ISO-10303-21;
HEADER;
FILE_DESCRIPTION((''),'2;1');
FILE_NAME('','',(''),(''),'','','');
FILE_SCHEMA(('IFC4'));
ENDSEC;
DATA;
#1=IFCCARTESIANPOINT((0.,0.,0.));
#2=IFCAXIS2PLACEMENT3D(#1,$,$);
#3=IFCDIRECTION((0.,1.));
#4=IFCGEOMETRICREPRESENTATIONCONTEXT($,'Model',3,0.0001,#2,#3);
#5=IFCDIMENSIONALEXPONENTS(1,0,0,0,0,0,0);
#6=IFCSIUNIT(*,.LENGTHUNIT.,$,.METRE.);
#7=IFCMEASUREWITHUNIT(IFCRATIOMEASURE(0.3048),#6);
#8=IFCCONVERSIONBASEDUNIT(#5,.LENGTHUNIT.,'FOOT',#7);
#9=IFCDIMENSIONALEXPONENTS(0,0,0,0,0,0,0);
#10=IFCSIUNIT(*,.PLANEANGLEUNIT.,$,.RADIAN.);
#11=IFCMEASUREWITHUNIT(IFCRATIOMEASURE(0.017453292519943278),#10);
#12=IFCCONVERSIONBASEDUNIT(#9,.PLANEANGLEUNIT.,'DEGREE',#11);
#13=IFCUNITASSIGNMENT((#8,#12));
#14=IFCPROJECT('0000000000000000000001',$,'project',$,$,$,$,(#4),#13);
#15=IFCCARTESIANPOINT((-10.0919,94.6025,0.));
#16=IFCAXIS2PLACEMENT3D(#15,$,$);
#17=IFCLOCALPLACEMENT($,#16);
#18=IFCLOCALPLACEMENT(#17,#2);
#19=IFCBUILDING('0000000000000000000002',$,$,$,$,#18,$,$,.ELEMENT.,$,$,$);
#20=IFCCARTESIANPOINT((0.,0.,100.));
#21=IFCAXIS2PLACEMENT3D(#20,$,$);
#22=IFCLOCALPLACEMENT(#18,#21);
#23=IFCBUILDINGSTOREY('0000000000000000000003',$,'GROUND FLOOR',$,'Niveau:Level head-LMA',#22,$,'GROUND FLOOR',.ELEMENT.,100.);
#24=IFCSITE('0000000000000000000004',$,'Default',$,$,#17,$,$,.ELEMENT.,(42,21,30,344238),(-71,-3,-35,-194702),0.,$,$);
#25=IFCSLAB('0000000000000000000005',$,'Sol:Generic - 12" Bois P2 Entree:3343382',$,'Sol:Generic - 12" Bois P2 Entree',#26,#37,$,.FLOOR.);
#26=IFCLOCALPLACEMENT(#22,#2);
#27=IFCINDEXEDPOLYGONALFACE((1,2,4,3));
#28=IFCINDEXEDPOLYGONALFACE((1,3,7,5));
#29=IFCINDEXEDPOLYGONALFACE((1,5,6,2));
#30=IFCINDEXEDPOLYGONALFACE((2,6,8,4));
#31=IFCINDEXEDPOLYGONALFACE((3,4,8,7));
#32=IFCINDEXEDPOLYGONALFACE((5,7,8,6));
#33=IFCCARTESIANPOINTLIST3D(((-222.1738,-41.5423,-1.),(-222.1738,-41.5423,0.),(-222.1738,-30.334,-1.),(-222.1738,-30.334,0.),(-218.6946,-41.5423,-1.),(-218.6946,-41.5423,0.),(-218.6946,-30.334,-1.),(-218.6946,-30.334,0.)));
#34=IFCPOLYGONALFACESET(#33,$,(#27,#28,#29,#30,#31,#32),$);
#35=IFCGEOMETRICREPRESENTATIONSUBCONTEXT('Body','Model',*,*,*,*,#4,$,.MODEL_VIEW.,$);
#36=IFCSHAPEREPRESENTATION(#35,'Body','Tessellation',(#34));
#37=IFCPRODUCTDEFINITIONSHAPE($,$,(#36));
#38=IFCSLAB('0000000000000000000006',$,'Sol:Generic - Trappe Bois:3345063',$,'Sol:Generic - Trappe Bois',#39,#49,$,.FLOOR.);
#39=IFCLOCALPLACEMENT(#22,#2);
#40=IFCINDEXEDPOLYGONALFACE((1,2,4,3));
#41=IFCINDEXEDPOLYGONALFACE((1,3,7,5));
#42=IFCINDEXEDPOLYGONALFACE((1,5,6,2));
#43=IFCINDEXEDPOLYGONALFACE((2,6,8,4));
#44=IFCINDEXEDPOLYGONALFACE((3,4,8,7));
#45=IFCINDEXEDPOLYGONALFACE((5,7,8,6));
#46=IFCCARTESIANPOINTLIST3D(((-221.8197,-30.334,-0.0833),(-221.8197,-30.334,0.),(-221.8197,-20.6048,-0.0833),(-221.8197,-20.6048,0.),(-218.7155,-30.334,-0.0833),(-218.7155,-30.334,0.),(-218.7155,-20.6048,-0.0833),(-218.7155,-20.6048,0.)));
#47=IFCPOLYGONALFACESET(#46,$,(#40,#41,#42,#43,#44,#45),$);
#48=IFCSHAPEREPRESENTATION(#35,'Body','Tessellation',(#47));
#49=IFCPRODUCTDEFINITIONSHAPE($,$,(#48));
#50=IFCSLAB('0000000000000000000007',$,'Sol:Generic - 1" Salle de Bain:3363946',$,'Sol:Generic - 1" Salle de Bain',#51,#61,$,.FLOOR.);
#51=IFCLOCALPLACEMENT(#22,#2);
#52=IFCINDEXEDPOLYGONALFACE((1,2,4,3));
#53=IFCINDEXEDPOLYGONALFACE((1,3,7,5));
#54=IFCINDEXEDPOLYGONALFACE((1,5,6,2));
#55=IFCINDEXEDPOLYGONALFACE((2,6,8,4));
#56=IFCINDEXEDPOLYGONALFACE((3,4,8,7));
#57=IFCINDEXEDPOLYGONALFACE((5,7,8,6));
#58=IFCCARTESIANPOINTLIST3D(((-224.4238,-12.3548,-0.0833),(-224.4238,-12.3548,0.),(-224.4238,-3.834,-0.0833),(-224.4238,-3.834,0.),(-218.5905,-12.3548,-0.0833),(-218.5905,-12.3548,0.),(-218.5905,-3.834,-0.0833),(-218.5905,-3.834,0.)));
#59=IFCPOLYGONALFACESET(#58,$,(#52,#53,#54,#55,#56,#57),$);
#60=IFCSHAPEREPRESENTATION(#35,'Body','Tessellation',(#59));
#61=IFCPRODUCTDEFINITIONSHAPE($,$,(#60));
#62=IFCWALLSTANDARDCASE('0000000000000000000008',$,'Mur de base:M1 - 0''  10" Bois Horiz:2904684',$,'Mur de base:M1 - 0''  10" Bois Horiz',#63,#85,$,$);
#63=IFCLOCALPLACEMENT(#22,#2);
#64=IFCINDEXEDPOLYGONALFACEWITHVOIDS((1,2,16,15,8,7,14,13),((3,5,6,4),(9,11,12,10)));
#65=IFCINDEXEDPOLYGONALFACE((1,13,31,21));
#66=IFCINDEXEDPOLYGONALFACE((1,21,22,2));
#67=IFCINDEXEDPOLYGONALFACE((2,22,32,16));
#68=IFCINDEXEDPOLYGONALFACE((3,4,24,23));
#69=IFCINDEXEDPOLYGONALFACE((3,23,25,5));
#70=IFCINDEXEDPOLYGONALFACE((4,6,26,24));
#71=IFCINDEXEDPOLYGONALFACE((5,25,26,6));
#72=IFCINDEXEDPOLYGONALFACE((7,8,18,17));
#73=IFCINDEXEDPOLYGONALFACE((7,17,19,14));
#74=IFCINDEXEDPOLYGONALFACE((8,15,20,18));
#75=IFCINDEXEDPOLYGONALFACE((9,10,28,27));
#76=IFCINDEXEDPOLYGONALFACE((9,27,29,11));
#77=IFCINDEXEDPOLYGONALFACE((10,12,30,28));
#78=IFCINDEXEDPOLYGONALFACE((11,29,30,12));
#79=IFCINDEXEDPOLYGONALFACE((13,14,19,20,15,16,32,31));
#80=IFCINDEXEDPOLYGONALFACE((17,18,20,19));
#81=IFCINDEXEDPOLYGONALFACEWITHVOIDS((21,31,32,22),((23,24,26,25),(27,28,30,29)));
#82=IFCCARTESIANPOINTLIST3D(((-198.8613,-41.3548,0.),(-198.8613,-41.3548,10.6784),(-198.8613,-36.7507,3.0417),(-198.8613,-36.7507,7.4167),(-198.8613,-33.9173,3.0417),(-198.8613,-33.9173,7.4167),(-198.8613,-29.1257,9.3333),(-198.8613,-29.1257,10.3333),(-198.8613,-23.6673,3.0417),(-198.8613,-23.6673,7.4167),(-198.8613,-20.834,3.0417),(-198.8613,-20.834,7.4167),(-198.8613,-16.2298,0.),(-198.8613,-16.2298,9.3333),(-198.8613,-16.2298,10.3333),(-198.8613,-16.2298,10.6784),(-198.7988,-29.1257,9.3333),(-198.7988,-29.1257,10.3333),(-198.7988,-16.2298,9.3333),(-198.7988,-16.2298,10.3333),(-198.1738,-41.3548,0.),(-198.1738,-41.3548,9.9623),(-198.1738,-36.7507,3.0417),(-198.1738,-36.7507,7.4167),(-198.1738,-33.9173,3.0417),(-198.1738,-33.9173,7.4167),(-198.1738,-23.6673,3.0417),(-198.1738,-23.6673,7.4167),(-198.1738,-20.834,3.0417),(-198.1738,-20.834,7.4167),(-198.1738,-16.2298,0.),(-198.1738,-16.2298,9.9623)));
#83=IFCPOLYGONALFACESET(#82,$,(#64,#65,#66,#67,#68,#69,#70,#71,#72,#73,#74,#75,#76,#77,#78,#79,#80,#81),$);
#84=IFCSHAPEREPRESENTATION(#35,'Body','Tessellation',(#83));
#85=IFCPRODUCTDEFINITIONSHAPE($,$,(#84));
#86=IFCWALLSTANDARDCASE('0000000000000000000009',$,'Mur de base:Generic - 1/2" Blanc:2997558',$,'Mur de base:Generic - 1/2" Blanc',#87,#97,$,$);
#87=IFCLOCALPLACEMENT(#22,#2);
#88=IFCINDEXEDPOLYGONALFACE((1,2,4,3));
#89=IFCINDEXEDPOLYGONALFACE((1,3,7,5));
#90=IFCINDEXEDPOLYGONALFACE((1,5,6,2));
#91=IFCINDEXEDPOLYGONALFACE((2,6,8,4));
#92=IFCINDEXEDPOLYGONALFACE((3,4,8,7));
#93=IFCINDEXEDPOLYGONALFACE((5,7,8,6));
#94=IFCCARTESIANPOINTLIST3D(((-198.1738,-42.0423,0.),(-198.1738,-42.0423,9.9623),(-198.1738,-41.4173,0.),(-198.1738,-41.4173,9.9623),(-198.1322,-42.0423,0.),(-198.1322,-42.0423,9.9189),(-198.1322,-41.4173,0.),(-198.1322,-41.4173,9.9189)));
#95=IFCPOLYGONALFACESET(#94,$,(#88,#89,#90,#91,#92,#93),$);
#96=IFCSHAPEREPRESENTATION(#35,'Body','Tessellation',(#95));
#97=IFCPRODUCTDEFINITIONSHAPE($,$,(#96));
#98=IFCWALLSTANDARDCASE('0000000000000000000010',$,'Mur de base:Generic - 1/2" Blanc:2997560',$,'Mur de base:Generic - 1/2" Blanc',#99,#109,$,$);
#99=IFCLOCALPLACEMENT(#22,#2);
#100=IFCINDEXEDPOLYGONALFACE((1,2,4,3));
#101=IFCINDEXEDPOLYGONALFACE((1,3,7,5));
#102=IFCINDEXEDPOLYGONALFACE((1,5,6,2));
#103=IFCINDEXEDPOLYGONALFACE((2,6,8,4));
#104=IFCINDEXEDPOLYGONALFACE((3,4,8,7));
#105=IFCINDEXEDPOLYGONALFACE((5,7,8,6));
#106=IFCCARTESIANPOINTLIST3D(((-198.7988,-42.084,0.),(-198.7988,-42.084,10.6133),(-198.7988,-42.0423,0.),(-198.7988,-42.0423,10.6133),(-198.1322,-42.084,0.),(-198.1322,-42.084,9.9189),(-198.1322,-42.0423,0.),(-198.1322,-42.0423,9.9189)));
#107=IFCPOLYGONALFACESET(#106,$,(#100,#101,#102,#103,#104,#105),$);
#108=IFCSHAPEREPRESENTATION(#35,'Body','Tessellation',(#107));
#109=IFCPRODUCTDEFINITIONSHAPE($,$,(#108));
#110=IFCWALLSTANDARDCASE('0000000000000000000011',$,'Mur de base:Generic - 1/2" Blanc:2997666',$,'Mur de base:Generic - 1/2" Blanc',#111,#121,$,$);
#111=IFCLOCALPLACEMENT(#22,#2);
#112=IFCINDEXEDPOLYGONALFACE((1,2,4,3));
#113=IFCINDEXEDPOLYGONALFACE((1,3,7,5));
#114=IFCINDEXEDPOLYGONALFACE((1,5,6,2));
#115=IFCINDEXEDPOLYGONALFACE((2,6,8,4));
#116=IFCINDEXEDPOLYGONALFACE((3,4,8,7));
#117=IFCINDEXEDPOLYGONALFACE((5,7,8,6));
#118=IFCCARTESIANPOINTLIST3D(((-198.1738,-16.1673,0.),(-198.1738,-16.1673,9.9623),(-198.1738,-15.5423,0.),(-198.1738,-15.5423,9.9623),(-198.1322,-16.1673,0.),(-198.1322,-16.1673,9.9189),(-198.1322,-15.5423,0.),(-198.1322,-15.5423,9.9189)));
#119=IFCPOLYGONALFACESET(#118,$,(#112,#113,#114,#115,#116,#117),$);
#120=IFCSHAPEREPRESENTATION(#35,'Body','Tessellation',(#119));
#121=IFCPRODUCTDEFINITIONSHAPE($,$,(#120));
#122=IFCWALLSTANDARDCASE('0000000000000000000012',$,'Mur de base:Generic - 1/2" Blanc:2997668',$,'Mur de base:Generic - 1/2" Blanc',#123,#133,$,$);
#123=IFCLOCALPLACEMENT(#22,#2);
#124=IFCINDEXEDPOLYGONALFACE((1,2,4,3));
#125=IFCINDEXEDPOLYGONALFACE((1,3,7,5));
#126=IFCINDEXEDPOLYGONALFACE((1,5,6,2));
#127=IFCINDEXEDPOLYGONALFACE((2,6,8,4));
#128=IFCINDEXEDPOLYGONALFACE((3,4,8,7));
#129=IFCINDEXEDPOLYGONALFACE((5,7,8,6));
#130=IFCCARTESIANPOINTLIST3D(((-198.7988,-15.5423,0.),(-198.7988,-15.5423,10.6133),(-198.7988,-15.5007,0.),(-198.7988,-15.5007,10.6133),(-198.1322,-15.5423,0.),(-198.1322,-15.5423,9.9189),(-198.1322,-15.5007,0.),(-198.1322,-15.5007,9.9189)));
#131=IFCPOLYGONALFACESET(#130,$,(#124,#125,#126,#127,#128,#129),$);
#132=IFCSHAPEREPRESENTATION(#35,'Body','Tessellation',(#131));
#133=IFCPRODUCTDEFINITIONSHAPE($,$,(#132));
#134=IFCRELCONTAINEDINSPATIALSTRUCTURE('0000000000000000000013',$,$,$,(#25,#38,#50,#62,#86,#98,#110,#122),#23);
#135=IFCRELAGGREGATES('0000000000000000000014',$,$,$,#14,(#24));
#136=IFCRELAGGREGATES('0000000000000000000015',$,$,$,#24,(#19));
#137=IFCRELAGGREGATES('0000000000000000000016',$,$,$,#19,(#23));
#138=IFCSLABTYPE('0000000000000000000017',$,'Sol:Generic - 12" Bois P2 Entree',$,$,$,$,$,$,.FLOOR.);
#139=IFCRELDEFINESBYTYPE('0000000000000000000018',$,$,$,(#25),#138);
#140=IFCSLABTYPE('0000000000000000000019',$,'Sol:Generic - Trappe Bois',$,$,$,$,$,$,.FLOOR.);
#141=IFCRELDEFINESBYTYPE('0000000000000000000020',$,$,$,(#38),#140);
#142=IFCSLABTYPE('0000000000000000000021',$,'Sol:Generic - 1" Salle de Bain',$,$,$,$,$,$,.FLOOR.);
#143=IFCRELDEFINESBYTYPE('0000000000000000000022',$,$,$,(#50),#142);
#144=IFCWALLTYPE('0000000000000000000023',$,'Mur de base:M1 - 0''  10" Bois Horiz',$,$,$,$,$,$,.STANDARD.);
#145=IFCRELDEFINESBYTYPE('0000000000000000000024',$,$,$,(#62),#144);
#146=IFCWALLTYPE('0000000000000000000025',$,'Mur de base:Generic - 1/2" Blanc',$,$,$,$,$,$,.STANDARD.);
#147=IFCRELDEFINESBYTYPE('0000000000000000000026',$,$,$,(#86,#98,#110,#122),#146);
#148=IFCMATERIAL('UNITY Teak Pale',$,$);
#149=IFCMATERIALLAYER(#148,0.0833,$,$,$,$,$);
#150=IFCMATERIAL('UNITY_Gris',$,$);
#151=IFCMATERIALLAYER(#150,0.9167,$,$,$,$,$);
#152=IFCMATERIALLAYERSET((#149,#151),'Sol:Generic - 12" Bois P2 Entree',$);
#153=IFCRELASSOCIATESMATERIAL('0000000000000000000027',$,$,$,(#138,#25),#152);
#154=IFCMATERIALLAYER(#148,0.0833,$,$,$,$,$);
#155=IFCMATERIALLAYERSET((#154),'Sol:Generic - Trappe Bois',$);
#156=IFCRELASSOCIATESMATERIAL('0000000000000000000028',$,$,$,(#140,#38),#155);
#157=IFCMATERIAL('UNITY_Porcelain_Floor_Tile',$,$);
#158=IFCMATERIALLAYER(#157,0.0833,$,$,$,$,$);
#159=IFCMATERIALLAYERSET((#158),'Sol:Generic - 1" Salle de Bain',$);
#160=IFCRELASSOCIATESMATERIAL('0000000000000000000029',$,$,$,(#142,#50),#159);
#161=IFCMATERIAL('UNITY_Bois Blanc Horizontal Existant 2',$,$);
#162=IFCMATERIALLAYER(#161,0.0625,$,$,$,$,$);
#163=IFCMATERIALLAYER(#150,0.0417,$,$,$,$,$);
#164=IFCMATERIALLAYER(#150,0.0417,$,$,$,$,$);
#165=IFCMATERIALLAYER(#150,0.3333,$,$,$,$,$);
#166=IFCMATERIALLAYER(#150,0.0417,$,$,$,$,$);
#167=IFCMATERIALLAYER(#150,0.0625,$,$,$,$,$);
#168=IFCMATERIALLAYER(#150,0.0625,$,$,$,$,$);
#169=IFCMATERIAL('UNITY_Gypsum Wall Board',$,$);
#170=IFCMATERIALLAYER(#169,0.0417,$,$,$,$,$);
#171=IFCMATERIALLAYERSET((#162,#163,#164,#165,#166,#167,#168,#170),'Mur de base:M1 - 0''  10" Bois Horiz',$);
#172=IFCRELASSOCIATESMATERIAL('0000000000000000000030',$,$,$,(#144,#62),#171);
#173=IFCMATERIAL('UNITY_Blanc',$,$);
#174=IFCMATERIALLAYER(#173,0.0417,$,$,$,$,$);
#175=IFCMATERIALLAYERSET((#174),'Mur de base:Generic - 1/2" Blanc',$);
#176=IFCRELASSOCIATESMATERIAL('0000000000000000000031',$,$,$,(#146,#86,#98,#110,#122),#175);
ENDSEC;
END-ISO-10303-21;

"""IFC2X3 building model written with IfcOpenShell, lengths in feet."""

from ifc_helpers import new_model, entity, si_unit, converted_unit, direction, frame, frame_2d, origin, place, context, subcontext, project, spatial, polyline, rectangle, extrude, clip, bounded_halfspace, material, layer, layer_set, layer_usage, type_object, element, save


model = new_model("IFC2X3")

# Units and contexts
model_context = context("Model", 3, precision=0.0001, world=origin(), true_north=direction((0.0, 1.0)))
body_context = subcontext(model_context, "Body", "Model", "MODEL_VIEW")
ifc_project = project(units=[converted_unit("LENGTHUNIT", "FOOT", entity("IfcRatioMeasure", 0.3048), si_unit("LENGTHUNIT", "METRE"), dimensions=[1, 0, 0, 0, 0, 0, 0]), converted_unit("PLANEANGLEUNIT", "DEGREE", entity("IfcRatioMeasure", 0.017453292519943278), si_unit("PLANEANGLEUNIT", "RADIAN"), dimensions=[0, 0, 0, 0, 0, 0, 0])], contexts=[model_context])

# Site, building, storey
site_placement = place(None, frame((-10.0919, 94.6025, 0.0)))
site = spatial("IfcSite", under=ifc_project, at=site_placement, Name="Default", CompositionType="ELEMENT", RefLatitude=(42, 21, 30, 344238), RefLongitude=(-71, -3, -35, -194702), RefElevation=0.0)
building_placement = place(site_placement, origin())
building = spatial("IfcBuilding", under=site, at=building_placement, CompositionType="ELEMENT")
storey_placement = place(building_placement, frame((0.0, 0.0, 100.0)))
storey = spatial("IfcBuildingStorey", under=building, at=storey_placement, Name="GROUND FLOOR", ObjectType="Niveau:Level head-LMA", LongName="GROUND FLOOR", CompositionType="ELEMENT", Elevation=100.0)

# Slabs
ifc_material_1 = material(Name="UNITY_Gris")
ifc_material_2 = material(Name="UNITY Teak Pale")
ifc_layer_1 = layer(ifc_material_2, 0.0833)
ifc_layer_2 = layer(ifc_material_1, 0.9167)
ifc_layer_set_1 = layer_set([ifc_layer_1, ifc_layer_2], Name="Sol:Generic - 12\" Bois P2 Entree")
ifc_layer_usage_1 = layer_usage(ifc_layer_set_1, "AXIS3", "POSITIVE", 0.0)
slab_type_1 = type_object("IfcSlabType", Name="Sol:Generic - 12\" Bois P2 Entree", PredefinedType="FLOOR", material=ifc_layer_set_1)
slab_1_placement = place(storey_placement, origin())
element("IfcSlab", 1, at=slab_1_placement, inside=storey, type_object=slab_type_1, material=ifc_layer_usage_1, Name="Sol:Generic - 12\" Bois P2 Entree:3343382", ObjectType="Sol:Generic - 12\" Bois P2 Entree", PredefinedType="FLOOR", context=body_context, shape_type="SweptSolid", body=[
    extrude(rectangle(XDim=11.2083, YDim=3.4792, at=frame_2d((0.0, 0.0), x_axis=(1.0, 0.0))), frame((-220.4342, -35.9382, 0.0), z_axis=(0.0, 0.0, -1.0), x_axis=(0.0, 1.0, 0.0)), (0.0, 0.0, 1.0), 1.0),
])
ifc_layer_3 = layer(ifc_material_2, 0.0833)
ifc_layer_set_2 = layer_set([ifc_layer_3], Name="Sol:Generic - Trappe Bois")
ifc_layer_usage_2 = layer_usage(ifc_layer_set_2, "AXIS3", "POSITIVE", 0.0)
slab_type_2 = type_object("IfcSlabType", Name="Sol:Generic - Trappe Bois", PredefinedType="FLOOR", material=ifc_layer_set_2)
slab_2_placement = place(storey_placement, origin())
element("IfcSlab", 2, at=slab_2_placement, inside=storey, type_object=slab_type_2, material=ifc_layer_usage_2, Name="Sol:Generic - Trappe Bois:3345063", ObjectType="Sol:Generic - Trappe Bois", PredefinedType="FLOOR", context=body_context, shape_type="SweptSolid", body=[
    extrude(rectangle(XDim=9.7292, YDim=3.1042, at=frame_2d((0.0, 0.0), x_axis=(1.0, 0.0))), frame((-220.2676, -25.4694, 0.0), z_axis=(0.0, 0.0, -1.0), x_axis=(0.0, 1.0, 0.0)), (0.0, 0.0, 1.0), 0.0833),
])
ifc_material_3 = material(Name="UNITY_Porcelain_Floor_Tile")
ifc_layer_4 = layer(ifc_material_3, 0.0833)
ifc_layer_set_3 = layer_set([ifc_layer_4], Name="Sol:Generic - 1\" Salle de Bain")
ifc_layer_usage_3 = layer_usage(ifc_layer_set_3, "AXIS3", "POSITIVE", 0.0)
slab_type_3 = type_object("IfcSlabType", Name="Sol:Generic - 1\" Salle de Bain", PredefinedType="FLOOR", material=ifc_layer_set_3)
slab_3_placement = place(storey_placement, origin())
element("IfcSlab", 3, at=slab_3_placement, inside=storey, type_object=slab_type_3, material=ifc_layer_usage_3, Name="Sol:Generic - 1\" Salle de Bain:3363946", ObjectType="Sol:Generic - 1\" Salle de Bain", PredefinedType="FLOOR", context=body_context, shape_type="SweptSolid", body=[
    extrude(rectangle(XDim=8.5208, YDim=5.8333, at=frame_2d((0.0, 0.0), x_axis=(1.0, 0.0))), frame((-221.5072, -8.0944, 0.0), z_axis=(0.0, 0.0, -1.0), x_axis=(0.0, 1.0, 0.0)), (0.0, 0.0, 1.0), 0.0833),
])

# Wall, openings
ifc_material_4 = material(Name="UNITY_Bois Blanc Horizontal Existant 2")
ifc_layer_5 = layer(ifc_material_4, 0.0625)
ifc_layer_6 = layer(ifc_material_1, 0.0417)
ifc_layer_7 = layer(ifc_material_1, 0.0417)
ifc_layer_8 = layer(ifc_material_1, 0.3333)
ifc_layer_9 = layer(ifc_material_1, 0.0417)
ifc_layer_10 = layer(ifc_material_1, 0.0625)
ifc_layer_11 = layer(ifc_material_1, 0.0625)
ifc_material_5 = material(Name="UNITY_Gypsum Wall Board")
ifc_layer_12 = layer(ifc_material_5, 0.0417)
ifc_layer_set_4 = layer_set([ifc_layer_5, ifc_layer_6, ifc_layer_7, ifc_layer_8, ifc_layer_9, ifc_layer_10, ifc_layer_11, ifc_layer_12], Name="Mur de base:M1 - 0'  10\" Bois Horiz")
ifc_layer_usage_4 = layer_usage(ifc_layer_set_4, "AXIS2", "NEGATIVE", 0.3438)
wall_type_1 = type_object("IfcWallType", Name="Mur de base:M1 - 0'  10\" Bois Horiz", PredefinedType="STANDARD", material=ifc_layer_set_4)
wall_1_placement = place(storey_placement, frame((-198.5176, -16.2298, 0.0), z_axis=(0.0, 0.0, 1.0), x_axis=(0.0, -1.0, 0.0)))
wall_1 = element("IfcWallStandardCase", 4, at=wall_1_placement, inside=storey, type_object=wall_type_1, material=ifc_layer_usage_4, Name="Mur de base:M1 - 0'  10\" Bois Horiz:2904684", ObjectType="Mur de base:M1 - 0'  10\" Bois Horiz", context=body_context, shape_type="Clipping", body=[
    clip(extrude(rectangle(XDim=25.125, YDim=0.6875, at=frame_2d((12.5625, 0.0), x_axis=(-1.0, 0.0))), origin(), (0.0, 0.0, 1.0), 10.6784), bounded_halfspace(frame((0.0, -0.3437, 10.6784), z_axis=(0.0, 0.721387, 0.692532), x_axis=(-1.0, 0.0, 0.0)), False, frame((0.0, -0.3437, 10.6784)), polyline([(0.0, 0.0), (25.125, 0.0), (25.125, 0.6875), (0.0, 0.6875), (0.0, 0.0)]))),
])
opening_1_placement = place(storey_placement, frame((-198.5176, -16.2298, 0.0), z_axis=(0.0, 0.0, 1.0), x_axis=(0.0, -1.0, 0.0)))
element("IfcOpeningElement", 5, at=opening_1_placement, cuts=wall_1, ObjectType="Opening", context=body_context, shape_type="SweptSolid", body=[
    extrude(rectangle(XDim=0.0625, YDim=12.8958, at=frame_2d((0.0, 0.0), x_axis=(1.0, 0.0))), frame((6.4479, -0.3125, 9.3333), z_axis=(0.0, 0.0, 1.0), x_axis=(0.0, 1.0, 0.0)), (0.0, 0.0, 1.0), 1.0),
])
opening_2_placement = place(wall_1_placement, frame((-16.2298, 198.5176, 0.0), z_axis=(0.0, 0.0, 1.0), x_axis=(0.0, 1.0, 0.0)))
element("IfcOpeningElement", 6, at=opening_2_placement, cuts=wall_1, ObjectType="Opening", context=body_context, shape_type="SweptSolid", body=[
    extrude(rectangle(XDim=4.375, YDim=2.8333, at=frame_2d((0.0, 0.0), x_axis=(1.0, 0.0))), frame((-203.8613, -22.2507, 5.2292), z_axis=(1.0, 0.0, 0.0), x_axis=(0.0, 0.0, 1.0)), (0.0, 0.0, 1.0), 10.0),
])
opening_3_placement = place(wall_1_placement, frame((-16.2298, 198.5176, 0.0), z_axis=(0.0, 0.0, 1.0), x_axis=(0.0, 1.0, 0.0)))
element("IfcOpeningElement", 7, at=opening_3_placement, cuts=wall_1, ObjectType="Opening", context=body_context, shape_type="SweptSolid", body=[
    extrude(rectangle(XDim=4.375, YDim=2.8333, at=frame_2d((0.0, 0.0), x_axis=(1.0, 0.0))), frame((-203.8613, -35.334, 5.2292), z_axis=(1.0, 0.0, 0.0), x_axis=(0.0, 0.0, 1.0)), (0.0, 0.0, 1.0), 10.0),
])

# Walls
ifc_material_6 = material(Name="UNITY_Blanc")
ifc_layer_13 = layer(ifc_material_6, 0.0417)
ifc_layer_set_5 = layer_set([ifc_layer_13], Name="Mur de base:Generic - 1/2\" Blanc")
ifc_layer_usage_5 = layer_usage(ifc_layer_set_5, "AXIS2", "NEGATIVE", 0.0208)
wall_type_2 = type_object("IfcWallType", Name="Mur de base:Generic - 1/2\" Blanc", PredefinedType="STANDARD", material=ifc_layer_set_5)
wall_2_placement = place(storey_placement, frame((-198.153, -41.4173, 0.0), z_axis=(0.0, 0.0, 1.0), x_axis=(0.0, -1.0, 0.0)))
element("IfcWallStandardCase", 8, at=wall_2_placement, inside=storey, type_object=wall_type_2, material=ifc_layer_usage_5, Name="Mur de base:Generic - 1/2\" Blanc:2997558", ObjectType="Mur de base:Generic - 1/2\" Blanc", context=body_context, shape_type="Clipping", body=[
    clip(extrude(rectangle(XDim=0.625, YDim=0.0417, at=frame_2d((0.3125, 0.0), x_axis=(-1.0, 0.0))), origin(), (0.0, 0.0, 1.0), 9.9623), bounded_halfspace(frame((0.0, -0.0208, 9.9623), z_axis=(0.0, 0.721387, 0.692532), x_axis=(-1.0, 0.0, 0.0)), False, frame((0.0, -0.0208, 9.9623)), polyline([(0.0, 0.0), (0.625, 0.0), (0.625, 0.0417), (0.0, 0.0417), (0.0, 0.0)]))),
])
ifc_layer_usage_6 = layer_usage(ifc_layer_set_5, "AXIS2", "NEGATIVE", 0.0208)
wall_3_placement = place(storey_placement, frame((-198.1322, -42.0632, 0.0), z_axis=(0.0, 0.0, 1.0), x_axis=(-1.0, 0.0, 0.0)))
element("IfcWallStandardCase", 9, at=wall_3_placement, inside=storey, type_object=wall_type_2, material=ifc_layer_usage_6, Name="Mur de base:Generic - 1/2\" Blanc:2997560", ObjectType="Mur de base:Generic - 1/2\" Blanc", context=body_context, shape_type="Clipping", body=[
    clip(extrude(rectangle(XDim=0.6667, YDim=0.0417, at=frame_2d((0.3333, 0.0), x_axis=(-1.0, 0.0))), origin(), (0.0, 0.0, 1.0), 10.6133), bounded_halfspace(frame((0.0, -0.0208, 9.9189), z_axis=(-0.721387, 0.0, 0.692532), x_axis=(0.0, -1.0, 0.0)), False, frame((0.0, -0.0208, 9.9189)), polyline([(0.0, 0.0), (0.0417, 0.0), (0.6667, 0.0), (0.6667, 0.0417), (0.0, 0.0417), (0.0, 0.0)]))),
])
ifc_layer_usage_7 = layer_usage(ifc_layer_set_5, "AXIS2", "POSITIVE", -0.0208)
wall_4_placement = place(storey_placement, frame((-198.153, -16.1673, 0.0), z_axis=(0.0, 0.0, 1.0), x_axis=(0.0, 1.0, 0.0)))
element("IfcWallStandardCase", 10, at=wall_4_placement, inside=storey, type_object=wall_type_2, material=ifc_layer_usage_7, Name="Mur de base:Generic - 1/2\" Blanc:2997666", ObjectType="Mur de base:Generic - 1/2\" Blanc", context=body_context, shape_type="Clipping", body=[
    clip(extrude(rectangle(XDim=0.625, YDim=0.0417, at=frame_2d((0.3125, 0.0), x_axis=(-1.0, 0.0))), origin(), (0.0, 0.0, 1.0), 9.9623), bounded_halfspace(frame((0.0, -0.0208, 9.9189), z_axis=(0.0, -0.721387, 0.692532), x_axis=(1.0, 0.0, 0.0)), False, frame((0.0, -0.0208, 9.9189)), polyline([(0.0, 0.0), (0.625, 0.0), (0.625, 0.0417), (0.0, 0.0417), (0.0, 0.0)]))),
])
ifc_layer_usage_8 = layer_usage(ifc_layer_set_5, "AXIS2", "POSITIVE", -0.0208)
wall_5_placement = place(storey_placement, frame((-198.1322, -15.5215, 0.0), z_axis=(0.0, 0.0, 1.0), x_axis=(-1.0, 0.0, 0.0)))
element("IfcWallStandardCase", 11, at=wall_5_placement, inside=storey, type_object=wall_type_2, material=ifc_layer_usage_8, Name="Mur de base:Generic - 1/2\" Blanc:2997668", ObjectType="Mur de base:Generic - 1/2\" Blanc", context=body_context, shape_type="Clipping", body=[
    clip(extrude(rectangle(XDim=0.6667, YDim=0.0417, at=frame_2d((0.3333, 0.0), x_axis=(-1.0, 0.0))), origin(), (0.0, 0.0, 1.0), 10.6133), bounded_halfspace(frame((0.0, -0.0208, 9.9189), z_axis=(-0.721387, 0.0, 0.692532), x_axis=(0.0, -1.0, 0.0)), False, frame((0.0, -0.0208, 9.9189)), polyline([(0.0, 0.0), (0.6667, 0.0), (0.6667, 0.0417), (0.0417, 0.0417), (0.0, 0.0417), (0.0, 0.0)]))),
])

save(model, "model.ifc")
